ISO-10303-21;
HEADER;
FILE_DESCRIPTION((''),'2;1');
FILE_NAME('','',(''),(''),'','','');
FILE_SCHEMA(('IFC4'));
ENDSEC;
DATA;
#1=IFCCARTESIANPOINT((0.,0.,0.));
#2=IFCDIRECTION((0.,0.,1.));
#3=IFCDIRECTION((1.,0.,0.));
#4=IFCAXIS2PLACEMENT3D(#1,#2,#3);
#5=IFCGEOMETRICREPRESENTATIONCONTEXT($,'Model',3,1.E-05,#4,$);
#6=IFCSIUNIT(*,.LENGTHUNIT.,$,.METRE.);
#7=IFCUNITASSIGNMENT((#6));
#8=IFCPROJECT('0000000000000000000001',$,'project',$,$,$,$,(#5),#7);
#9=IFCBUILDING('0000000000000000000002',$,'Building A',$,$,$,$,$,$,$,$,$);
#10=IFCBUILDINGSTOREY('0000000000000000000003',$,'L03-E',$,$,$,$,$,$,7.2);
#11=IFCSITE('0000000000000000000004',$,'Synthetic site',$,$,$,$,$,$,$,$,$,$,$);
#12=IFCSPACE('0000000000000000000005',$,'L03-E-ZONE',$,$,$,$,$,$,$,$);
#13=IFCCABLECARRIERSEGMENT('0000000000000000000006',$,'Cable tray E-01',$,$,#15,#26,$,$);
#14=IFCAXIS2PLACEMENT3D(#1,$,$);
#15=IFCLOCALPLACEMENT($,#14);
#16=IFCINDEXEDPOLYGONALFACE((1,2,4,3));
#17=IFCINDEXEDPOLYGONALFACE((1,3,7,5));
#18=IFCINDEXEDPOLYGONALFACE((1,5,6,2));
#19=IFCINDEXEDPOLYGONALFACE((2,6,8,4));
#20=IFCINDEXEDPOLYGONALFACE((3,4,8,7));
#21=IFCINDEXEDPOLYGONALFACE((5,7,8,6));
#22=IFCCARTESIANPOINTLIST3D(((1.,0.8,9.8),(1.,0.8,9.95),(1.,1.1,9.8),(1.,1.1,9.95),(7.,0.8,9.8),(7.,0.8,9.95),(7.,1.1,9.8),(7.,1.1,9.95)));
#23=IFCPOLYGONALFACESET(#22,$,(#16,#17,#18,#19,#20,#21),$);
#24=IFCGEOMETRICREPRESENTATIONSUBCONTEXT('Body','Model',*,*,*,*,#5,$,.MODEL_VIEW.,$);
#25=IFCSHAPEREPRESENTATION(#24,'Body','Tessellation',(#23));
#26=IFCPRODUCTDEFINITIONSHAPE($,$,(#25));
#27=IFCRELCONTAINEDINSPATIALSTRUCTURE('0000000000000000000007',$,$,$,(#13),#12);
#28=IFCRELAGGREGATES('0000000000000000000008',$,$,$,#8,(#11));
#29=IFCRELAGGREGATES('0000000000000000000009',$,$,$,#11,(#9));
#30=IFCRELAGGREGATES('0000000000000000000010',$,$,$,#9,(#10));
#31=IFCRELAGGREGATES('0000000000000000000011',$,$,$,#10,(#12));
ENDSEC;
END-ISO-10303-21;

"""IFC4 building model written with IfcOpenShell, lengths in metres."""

from ifc_helpers import new_model, si_unit, frame, origin_with_axes, place, context, subcontext, project, spatial, indexed_curve, outline, extrude, element, save


model = new_model("IFC4")

# Units and contexts
model_context = context("Model", 3, precision=1e-05, world=origin_with_axes())
body_context = subcontext(model_context, "Body", "Model", "MODEL_VIEW")
ifc_project = project(units=[si_unit("LENGTHUNIT", "METRE")], contexts=[model_context])

# Site, building, storey, space
site = spatial("IfcSite", under=ifc_project, Name="Synthetic site")
building = spatial("IfcBuilding", under=site, Name="Building A")
storey = spatial("IfcBuildingStorey", under=building, Name="L03-E", Elevation=7.2)
space = spatial("IfcSpace", under=storey, Name="L03-E-ZONE")

# Cable carrier segment
cable_carrier_segment_placement = place(None, frame((1.0, 0.8, 9.8), z_axis=(0.0, 0.0, 1.0), x_axis=(1.0, 0.0, 0.0)))
element("IfcCableCarrierSegment", 1, at=cable_carrier_segment_placement, inside=space, Name="Cable tray E-01", context=body_context, shape_type="SweptSolid", body=[
    extrude(outline(indexed_curve([(0.0, 0.0), (0.0, 0.3), (6.0, 0.3), (6.0, 0.0), (0.0, 0.0)], self_intersect=False)), origin_with_axes(), (0.0, 0.0, 1.0), 0.15),
])

save(model, "model.ifc")
